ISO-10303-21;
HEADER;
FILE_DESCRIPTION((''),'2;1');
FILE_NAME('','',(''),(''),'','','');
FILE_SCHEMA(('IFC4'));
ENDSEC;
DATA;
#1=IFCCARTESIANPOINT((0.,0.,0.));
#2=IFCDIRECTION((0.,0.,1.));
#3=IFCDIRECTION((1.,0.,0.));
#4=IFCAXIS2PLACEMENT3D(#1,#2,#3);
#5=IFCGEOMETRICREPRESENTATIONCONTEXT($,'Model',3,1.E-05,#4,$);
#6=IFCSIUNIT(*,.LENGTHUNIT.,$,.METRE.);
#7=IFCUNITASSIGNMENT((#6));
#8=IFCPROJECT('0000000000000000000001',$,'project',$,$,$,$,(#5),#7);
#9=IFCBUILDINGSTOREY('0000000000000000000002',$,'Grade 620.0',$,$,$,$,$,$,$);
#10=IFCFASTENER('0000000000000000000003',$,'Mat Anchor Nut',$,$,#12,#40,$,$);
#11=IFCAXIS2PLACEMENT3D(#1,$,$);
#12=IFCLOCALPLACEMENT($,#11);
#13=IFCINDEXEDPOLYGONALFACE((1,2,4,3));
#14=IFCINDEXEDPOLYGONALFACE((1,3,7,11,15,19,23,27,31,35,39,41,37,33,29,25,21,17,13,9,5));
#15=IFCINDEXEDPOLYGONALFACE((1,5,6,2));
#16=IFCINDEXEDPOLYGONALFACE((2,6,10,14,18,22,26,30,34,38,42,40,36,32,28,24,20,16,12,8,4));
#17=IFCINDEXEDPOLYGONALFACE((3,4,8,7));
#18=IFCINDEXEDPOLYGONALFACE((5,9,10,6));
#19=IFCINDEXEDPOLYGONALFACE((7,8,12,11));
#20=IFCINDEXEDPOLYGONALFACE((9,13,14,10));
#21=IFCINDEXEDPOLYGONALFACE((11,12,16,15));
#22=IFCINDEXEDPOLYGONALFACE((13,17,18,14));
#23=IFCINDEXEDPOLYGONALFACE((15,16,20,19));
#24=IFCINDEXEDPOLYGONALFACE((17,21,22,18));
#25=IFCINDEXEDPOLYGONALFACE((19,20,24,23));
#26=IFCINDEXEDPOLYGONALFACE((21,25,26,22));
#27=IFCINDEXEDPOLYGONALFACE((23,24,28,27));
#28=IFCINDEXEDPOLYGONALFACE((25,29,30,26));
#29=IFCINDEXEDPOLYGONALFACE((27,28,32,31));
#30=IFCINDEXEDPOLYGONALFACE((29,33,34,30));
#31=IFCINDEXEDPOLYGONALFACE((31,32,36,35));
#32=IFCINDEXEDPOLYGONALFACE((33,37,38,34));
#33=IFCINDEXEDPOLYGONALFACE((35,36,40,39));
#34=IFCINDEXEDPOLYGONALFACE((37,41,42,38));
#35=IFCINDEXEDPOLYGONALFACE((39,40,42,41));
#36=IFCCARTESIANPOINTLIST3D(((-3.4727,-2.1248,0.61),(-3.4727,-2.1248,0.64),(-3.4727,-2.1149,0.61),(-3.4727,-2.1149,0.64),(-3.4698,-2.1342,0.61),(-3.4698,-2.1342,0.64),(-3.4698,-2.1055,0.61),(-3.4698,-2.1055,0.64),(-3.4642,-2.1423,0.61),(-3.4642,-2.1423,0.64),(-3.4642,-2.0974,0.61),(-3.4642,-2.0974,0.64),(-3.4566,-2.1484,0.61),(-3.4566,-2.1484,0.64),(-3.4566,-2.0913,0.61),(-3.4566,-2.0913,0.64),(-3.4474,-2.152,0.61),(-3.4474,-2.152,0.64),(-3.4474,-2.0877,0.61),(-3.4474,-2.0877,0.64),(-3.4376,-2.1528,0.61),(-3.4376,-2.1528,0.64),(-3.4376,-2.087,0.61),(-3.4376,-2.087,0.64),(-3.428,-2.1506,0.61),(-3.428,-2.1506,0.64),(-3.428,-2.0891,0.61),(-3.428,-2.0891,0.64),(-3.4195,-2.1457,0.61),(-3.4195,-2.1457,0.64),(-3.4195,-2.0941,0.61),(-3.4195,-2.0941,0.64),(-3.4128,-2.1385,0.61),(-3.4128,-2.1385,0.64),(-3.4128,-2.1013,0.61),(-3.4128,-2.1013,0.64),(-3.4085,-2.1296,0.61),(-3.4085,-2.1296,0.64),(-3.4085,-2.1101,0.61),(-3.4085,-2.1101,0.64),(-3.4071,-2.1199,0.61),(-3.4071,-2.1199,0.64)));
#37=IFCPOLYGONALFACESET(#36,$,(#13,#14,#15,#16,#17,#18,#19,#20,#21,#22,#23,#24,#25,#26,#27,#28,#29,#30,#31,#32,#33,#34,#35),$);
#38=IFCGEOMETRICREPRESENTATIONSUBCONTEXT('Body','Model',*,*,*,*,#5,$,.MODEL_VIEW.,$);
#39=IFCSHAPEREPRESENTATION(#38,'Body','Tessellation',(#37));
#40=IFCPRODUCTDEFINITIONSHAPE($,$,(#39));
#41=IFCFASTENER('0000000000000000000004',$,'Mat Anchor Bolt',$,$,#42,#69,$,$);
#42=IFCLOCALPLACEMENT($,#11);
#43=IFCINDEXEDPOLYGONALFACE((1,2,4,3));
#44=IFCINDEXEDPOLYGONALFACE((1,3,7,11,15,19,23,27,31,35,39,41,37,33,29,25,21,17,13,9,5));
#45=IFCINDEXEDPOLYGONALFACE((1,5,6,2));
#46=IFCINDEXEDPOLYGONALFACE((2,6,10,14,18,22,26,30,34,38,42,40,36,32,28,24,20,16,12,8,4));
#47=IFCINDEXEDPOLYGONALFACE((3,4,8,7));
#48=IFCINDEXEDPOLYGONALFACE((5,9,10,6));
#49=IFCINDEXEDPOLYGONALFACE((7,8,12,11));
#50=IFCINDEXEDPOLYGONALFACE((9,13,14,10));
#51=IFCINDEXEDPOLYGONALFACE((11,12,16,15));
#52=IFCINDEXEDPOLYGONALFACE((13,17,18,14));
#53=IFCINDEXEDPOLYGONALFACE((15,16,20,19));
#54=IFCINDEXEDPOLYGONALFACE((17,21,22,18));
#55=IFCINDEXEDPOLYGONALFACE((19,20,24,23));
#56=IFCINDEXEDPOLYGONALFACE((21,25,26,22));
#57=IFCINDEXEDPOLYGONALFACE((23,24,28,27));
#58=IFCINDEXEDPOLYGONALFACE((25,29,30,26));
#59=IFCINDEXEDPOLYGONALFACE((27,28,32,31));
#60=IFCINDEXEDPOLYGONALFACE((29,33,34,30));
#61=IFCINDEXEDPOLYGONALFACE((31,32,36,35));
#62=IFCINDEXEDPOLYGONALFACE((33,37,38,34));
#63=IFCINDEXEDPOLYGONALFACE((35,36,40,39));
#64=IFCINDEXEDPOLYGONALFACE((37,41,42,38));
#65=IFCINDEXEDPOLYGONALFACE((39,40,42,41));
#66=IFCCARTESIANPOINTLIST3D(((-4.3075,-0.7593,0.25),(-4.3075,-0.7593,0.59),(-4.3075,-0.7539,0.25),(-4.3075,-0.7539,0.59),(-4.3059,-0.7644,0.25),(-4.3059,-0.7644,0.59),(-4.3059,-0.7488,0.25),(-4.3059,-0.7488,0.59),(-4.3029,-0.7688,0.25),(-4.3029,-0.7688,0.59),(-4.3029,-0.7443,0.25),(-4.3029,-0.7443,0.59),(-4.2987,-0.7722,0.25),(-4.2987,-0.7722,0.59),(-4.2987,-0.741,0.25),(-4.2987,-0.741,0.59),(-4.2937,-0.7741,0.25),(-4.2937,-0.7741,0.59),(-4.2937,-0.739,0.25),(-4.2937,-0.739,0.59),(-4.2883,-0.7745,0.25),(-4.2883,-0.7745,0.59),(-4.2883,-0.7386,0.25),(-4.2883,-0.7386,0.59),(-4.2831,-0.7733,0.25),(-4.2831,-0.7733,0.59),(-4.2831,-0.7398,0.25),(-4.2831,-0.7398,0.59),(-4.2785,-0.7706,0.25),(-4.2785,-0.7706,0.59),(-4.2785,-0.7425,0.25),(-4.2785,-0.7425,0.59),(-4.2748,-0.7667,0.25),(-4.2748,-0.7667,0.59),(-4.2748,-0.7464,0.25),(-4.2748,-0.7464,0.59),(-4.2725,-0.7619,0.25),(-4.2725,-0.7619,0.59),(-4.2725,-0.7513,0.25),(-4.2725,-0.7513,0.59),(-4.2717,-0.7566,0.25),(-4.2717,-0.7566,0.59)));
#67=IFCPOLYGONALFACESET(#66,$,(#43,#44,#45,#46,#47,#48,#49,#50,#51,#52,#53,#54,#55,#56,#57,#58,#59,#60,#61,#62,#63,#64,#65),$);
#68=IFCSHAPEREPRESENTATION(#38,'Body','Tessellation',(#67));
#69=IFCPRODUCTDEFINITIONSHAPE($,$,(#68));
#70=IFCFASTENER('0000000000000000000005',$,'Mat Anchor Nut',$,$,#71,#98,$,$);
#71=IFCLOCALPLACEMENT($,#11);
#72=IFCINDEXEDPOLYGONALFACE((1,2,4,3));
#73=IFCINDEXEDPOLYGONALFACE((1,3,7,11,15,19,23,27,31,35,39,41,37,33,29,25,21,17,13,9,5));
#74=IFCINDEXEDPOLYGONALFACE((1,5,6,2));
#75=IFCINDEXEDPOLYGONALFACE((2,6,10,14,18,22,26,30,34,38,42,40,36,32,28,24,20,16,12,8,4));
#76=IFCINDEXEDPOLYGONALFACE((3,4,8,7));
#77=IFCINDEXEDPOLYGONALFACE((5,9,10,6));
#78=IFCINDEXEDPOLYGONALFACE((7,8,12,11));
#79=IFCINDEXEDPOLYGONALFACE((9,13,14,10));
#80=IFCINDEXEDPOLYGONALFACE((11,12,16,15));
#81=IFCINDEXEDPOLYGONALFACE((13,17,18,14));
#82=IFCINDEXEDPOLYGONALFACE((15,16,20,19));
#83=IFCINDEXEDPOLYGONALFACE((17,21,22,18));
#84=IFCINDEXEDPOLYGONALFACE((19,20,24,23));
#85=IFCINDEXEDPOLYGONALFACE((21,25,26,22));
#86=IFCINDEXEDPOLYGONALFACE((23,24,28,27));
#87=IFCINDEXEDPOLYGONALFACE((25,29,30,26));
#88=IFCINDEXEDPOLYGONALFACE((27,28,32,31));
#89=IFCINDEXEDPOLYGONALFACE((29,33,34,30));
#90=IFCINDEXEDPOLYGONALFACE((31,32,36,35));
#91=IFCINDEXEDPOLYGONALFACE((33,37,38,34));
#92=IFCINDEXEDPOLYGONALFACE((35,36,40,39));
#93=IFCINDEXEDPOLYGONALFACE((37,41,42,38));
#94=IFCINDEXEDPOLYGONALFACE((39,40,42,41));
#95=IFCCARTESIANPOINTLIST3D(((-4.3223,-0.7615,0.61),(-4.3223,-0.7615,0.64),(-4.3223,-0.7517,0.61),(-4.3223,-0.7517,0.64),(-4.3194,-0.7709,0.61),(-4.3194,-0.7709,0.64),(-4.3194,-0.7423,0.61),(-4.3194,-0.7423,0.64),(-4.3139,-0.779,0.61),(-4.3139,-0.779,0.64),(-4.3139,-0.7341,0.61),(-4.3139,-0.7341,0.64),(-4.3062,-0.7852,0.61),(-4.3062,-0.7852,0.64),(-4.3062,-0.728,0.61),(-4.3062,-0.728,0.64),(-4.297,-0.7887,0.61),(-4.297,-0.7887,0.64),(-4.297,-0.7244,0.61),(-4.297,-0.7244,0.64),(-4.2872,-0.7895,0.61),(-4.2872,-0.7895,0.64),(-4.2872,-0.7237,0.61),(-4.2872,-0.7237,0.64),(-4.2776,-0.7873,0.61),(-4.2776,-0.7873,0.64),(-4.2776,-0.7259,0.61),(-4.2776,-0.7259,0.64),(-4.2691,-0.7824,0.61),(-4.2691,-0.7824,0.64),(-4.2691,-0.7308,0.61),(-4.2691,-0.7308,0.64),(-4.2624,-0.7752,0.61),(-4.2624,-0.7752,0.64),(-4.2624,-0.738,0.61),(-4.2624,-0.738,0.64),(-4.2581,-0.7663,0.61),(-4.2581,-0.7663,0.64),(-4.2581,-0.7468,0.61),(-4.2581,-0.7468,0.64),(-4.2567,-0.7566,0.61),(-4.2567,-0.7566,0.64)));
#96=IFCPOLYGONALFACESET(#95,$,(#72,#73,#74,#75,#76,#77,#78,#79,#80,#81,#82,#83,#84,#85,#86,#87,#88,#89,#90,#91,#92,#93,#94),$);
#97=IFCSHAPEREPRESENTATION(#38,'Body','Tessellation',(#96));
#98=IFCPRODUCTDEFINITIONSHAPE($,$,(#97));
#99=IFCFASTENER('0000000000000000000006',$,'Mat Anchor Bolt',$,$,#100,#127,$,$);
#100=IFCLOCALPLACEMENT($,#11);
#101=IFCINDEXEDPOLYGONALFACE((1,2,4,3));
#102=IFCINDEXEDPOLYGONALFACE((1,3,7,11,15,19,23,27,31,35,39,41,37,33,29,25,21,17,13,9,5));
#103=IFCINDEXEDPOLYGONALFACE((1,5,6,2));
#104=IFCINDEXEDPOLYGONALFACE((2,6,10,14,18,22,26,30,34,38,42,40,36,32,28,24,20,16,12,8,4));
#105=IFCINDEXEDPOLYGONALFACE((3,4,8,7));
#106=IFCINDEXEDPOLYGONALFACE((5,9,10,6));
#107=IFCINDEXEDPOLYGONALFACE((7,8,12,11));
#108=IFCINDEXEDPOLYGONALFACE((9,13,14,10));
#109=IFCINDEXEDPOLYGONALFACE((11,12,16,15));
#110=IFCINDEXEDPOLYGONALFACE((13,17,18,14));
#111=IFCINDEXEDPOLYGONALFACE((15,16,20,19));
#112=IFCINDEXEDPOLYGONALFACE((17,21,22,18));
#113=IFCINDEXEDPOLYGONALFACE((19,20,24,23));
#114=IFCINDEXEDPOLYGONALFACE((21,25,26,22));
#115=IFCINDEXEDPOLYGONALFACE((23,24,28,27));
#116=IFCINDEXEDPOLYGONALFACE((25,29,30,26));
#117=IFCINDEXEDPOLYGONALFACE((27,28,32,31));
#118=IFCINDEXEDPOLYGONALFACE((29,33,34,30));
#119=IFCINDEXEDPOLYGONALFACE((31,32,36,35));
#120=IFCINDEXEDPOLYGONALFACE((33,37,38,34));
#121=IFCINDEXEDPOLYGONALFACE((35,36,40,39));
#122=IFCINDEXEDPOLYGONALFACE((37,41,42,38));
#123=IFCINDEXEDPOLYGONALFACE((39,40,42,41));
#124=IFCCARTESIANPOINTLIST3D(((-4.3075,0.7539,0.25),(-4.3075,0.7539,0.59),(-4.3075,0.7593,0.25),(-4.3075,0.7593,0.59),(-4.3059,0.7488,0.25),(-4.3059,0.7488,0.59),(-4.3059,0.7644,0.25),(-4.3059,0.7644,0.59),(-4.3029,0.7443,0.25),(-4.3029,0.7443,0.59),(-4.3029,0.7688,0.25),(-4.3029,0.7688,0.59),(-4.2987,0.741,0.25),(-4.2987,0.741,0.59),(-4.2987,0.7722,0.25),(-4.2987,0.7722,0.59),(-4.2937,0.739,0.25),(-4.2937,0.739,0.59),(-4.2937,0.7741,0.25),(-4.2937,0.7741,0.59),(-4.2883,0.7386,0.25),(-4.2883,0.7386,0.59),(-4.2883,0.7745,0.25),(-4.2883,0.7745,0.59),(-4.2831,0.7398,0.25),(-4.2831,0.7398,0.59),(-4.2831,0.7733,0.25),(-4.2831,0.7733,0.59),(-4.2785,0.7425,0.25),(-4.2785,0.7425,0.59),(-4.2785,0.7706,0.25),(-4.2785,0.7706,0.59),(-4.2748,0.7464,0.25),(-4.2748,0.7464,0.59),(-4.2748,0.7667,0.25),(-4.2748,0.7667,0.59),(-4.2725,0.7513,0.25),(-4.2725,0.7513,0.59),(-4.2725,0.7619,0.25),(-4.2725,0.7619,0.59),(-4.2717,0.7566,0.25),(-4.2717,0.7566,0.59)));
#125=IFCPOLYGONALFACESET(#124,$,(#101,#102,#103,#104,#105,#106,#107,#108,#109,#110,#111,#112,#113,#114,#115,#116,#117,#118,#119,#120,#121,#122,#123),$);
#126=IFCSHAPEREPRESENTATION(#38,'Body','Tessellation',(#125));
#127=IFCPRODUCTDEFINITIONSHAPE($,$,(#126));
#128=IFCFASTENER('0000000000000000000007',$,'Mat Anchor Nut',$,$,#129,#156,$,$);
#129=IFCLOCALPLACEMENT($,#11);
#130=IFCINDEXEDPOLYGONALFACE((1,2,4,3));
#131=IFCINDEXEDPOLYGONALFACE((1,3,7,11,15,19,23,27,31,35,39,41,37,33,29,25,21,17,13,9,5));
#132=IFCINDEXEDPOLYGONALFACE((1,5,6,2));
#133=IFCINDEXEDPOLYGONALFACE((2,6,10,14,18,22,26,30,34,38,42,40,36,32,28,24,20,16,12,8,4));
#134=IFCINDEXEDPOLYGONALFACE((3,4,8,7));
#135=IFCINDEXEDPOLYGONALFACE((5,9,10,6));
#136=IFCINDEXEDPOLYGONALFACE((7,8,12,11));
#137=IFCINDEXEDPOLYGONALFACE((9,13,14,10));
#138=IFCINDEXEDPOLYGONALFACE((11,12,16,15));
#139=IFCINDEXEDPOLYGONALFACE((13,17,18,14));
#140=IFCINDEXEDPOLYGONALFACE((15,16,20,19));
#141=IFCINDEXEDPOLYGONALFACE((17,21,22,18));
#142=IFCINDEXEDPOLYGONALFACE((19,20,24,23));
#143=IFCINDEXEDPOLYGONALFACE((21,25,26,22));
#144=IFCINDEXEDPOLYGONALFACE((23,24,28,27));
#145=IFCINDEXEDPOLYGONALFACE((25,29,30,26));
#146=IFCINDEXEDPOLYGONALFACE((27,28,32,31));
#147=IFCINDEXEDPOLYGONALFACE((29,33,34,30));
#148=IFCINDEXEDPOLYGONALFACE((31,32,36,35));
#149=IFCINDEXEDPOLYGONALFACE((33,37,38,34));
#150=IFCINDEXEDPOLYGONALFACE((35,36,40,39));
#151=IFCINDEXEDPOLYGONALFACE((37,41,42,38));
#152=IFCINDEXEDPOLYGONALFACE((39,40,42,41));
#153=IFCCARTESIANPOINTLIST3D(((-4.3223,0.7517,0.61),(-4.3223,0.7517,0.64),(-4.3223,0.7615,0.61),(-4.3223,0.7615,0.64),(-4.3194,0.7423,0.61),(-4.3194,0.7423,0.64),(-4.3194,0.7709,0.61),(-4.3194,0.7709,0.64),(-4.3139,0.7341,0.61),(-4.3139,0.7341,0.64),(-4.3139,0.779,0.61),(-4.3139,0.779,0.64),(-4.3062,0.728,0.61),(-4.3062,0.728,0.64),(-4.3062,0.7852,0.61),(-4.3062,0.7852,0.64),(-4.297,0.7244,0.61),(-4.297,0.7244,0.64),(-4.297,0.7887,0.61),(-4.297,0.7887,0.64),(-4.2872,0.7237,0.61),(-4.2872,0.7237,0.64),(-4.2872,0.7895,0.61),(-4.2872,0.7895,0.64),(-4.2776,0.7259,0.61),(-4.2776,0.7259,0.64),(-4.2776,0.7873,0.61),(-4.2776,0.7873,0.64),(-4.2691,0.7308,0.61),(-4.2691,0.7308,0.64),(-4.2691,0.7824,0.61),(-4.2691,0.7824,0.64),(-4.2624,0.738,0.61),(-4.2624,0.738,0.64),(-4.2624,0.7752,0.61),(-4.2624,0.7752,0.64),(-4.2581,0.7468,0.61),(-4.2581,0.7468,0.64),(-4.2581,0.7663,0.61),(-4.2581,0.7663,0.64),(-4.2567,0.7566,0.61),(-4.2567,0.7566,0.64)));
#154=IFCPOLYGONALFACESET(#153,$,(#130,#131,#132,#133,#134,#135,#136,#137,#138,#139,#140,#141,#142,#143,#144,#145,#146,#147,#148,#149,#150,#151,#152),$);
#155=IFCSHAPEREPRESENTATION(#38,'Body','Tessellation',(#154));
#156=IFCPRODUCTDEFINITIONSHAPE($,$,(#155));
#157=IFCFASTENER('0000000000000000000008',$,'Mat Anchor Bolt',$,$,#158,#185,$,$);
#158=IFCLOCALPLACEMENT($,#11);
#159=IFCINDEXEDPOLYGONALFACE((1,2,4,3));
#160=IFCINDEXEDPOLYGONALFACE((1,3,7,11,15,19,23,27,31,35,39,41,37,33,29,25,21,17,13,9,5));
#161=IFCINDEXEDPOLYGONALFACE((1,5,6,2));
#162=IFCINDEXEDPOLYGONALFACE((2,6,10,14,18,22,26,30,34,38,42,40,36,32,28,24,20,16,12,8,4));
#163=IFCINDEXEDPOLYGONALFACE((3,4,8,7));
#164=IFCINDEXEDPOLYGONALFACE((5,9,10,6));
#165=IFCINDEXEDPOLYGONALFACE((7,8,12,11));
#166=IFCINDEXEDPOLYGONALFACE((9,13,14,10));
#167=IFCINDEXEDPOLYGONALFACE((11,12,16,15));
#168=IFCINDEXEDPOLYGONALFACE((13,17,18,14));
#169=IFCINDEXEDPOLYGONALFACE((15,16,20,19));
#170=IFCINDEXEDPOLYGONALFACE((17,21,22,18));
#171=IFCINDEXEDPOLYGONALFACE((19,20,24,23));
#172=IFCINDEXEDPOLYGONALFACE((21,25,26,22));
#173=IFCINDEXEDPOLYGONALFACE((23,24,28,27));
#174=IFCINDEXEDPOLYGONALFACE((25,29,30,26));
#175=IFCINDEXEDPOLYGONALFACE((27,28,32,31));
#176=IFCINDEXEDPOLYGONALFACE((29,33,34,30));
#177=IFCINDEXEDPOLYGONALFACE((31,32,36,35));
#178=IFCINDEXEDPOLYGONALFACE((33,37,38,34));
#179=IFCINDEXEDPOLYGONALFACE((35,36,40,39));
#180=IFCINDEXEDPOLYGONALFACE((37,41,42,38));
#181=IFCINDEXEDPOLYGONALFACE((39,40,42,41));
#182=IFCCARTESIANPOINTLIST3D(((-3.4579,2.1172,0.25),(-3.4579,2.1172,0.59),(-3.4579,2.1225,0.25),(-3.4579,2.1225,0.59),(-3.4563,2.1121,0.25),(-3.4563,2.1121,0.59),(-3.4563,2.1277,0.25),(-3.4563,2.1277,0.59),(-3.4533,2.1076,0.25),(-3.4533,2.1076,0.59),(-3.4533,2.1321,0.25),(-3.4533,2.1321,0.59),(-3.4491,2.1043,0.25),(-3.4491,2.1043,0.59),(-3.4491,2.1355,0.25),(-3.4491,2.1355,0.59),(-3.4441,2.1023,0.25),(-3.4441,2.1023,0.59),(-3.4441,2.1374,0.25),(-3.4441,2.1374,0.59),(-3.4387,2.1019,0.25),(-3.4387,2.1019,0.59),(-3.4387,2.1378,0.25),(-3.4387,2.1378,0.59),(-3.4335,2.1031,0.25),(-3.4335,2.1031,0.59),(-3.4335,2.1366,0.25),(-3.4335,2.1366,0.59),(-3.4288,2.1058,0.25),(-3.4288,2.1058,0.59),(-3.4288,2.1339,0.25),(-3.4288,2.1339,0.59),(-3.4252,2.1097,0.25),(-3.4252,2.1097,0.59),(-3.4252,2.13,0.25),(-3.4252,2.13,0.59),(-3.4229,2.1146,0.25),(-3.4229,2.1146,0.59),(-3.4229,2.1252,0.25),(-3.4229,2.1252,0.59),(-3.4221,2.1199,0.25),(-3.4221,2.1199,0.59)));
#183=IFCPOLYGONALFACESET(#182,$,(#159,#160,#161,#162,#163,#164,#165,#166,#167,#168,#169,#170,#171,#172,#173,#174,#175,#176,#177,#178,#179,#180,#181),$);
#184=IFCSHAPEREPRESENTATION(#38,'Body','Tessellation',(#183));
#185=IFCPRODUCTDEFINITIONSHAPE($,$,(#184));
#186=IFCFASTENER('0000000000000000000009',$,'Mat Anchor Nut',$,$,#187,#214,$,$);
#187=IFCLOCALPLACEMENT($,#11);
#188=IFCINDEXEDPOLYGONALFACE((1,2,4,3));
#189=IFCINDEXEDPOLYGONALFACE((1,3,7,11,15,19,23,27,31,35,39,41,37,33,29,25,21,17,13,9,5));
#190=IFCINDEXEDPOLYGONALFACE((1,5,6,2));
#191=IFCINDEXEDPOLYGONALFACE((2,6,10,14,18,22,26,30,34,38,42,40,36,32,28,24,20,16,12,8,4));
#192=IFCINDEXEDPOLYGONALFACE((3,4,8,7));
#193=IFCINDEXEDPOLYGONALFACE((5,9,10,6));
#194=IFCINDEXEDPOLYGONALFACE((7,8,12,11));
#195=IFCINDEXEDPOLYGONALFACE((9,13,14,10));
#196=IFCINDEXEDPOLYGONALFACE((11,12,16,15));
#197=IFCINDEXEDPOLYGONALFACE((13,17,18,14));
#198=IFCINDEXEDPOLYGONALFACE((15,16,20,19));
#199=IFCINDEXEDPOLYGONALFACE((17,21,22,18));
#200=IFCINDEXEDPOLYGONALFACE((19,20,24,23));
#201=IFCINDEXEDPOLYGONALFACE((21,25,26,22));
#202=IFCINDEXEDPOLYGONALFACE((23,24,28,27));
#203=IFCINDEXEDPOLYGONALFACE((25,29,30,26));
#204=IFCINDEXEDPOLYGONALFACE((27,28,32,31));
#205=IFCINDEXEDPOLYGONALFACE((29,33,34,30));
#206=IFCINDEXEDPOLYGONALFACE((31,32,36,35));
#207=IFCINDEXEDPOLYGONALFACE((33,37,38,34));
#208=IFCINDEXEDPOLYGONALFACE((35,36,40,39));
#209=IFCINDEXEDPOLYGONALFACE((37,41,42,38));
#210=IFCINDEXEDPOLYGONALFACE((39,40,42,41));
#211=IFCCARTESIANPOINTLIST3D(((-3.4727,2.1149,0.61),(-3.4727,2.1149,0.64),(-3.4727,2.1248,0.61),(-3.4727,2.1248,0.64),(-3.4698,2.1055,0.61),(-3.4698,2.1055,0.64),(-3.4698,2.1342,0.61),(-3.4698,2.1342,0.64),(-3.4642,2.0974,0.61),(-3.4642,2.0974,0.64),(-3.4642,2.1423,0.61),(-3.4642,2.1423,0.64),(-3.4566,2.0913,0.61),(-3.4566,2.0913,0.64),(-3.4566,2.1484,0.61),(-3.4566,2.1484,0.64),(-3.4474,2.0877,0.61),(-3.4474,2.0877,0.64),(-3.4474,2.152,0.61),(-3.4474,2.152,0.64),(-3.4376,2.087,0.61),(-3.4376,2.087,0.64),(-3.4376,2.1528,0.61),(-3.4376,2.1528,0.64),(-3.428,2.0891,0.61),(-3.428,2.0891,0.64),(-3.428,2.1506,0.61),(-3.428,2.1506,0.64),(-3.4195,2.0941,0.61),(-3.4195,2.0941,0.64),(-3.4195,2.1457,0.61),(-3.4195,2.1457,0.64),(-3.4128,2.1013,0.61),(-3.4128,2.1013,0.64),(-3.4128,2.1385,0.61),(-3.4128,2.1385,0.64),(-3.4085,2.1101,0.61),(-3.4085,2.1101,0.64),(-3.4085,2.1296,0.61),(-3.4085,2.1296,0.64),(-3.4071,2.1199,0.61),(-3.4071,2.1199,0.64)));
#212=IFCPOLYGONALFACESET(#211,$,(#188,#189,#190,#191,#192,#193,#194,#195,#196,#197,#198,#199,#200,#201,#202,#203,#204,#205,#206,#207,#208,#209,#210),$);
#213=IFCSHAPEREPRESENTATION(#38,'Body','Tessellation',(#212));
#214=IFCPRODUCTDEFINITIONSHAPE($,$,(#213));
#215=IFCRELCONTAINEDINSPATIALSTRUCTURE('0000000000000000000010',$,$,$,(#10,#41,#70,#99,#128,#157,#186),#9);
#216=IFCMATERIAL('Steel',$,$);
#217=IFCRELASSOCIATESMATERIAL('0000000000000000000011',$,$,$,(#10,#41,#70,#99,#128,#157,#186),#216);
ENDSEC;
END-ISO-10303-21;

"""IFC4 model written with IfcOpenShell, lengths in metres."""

from ifc_helpers import new_model, si_unit, frame, origin_with_axes, place, context, subcontext, project, spatial, circle, extrude, material, element, save


model = new_model("IFC4")

# Units and contexts
model_context = context("Model", 3, precision=1e-05, world=origin_with_axes())
body_context = subcontext(model_context, "Body", "Model", "MODEL_VIEW")
ifc_project = project(units=[si_unit("LENGTHUNIT", "METRE")], contexts=[model_context])

# Storey
storey = spatial("IfcBuildingStorey", Name="Grade 620.0")

# Fasteners
ifc_material_1 = material(Name="Steel")
fastener_1_placement = place(None, frame((-3.4401, -2.1199, 0.61), z_axis=(0.0, 0.0, 1.0), x_axis=(1.0, 0.0, 0.0)))
element("IfcFastener", 1, at=fastener_1_placement, inside=storey, material=ifc_material_1, Name="Mat Anchor Nut", context=body_context, shape_type="SweptSolid", body=[
    extrude(circle(Radius=0.033), origin_with_axes(), (0.0, 0.0, 1.0), 0.03),
])
fastener_2_placement = place(None, frame((-4.2897, -0.7566, 0.25), z_axis=(0.0, 0.0, 1.0), x_axis=(1.0, 0.0, 0.0)))
element("IfcFastener", 2, at=fastener_2_placement, inside=storey, material=ifc_material_1, Name="Mat Anchor Bolt", context=body_context, shape_type="SweptSolid", body=[
    extrude(circle(Radius=0.018), origin_with_axes(), (0.0, 0.0, 1.0), 0.34),
])
fastener_3_placement = place(None, frame((-4.2897, -0.7566, 0.61), z_axis=(0.0, 0.0, 1.0), x_axis=(1.0, 0.0, 0.0)))
element("IfcFastener", 3, at=fastener_3_placement, inside=storey, material=ifc_material_1, Name="Mat Anchor Nut", context=body_context, shape_type="SweptSolid", body=[
    extrude(circle(Radius=0.033), origin_with_axes(), (0.0, 0.0, 1.0), 0.03),
])
fastener_4_placement = place(None, frame((-4.2897, 0.7566, 0.25), z_axis=(0.0, 0.0, 1.0), x_axis=(1.0, 0.0, 0.0)))
element("IfcFastener", 4, at=fastener_4_placement, inside=storey, material=ifc_material_1, Name="Mat Anchor Bolt", context=body_context, shape_type="SweptSolid", body=[
    extrude(circle(Radius=0.018), origin_with_axes(), (0.0, 0.0, 1.0), 0.34),
])
fastener_5_placement = place(None, frame((-4.2897, 0.7566, 0.61), z_axis=(0.0, 0.0, 1.0), x_axis=(1.0, 0.0, 0.0)))
element("IfcFastener", 5, at=fastener_5_placement, inside=storey, material=ifc_material_1, Name="Mat Anchor Nut", context=body_context, shape_type="SweptSolid", body=[
    extrude(circle(Radius=0.033), origin_with_axes(), (0.0, 0.0, 1.0), 0.03),
])
fastener_6_placement = place(None, frame((-3.4401, 2.1199, 0.25), z_axis=(0.0, 0.0, 1.0), x_axis=(1.0, 0.0, 0.0)))
element("IfcFastener", 6, at=fastener_6_placement, inside=storey, material=ifc_material_1, Name="Mat Anchor Bolt", context=body_context, shape_type="SweptSolid", body=[
    extrude(circle(Radius=0.018), origin_with_axes(), (0.0, 0.0, 1.0), 0.34),
])
fastener_7_placement = place(None, frame((-3.4401, 2.1199, 0.61), z_axis=(0.0, 0.0, 1.0), x_axis=(1.0, 0.0, 0.0)))
element("IfcFastener", 7, at=fastener_7_placement, inside=storey, material=ifc_material_1, Name="Mat Anchor Nut", context=body_context, shape_type="SweptSolid", body=[
    extrude(circle(Radius=0.033), origin_with_axes(), (0.0, 0.0, 1.0), 0.03),
])

save(model, "model.ifc")
